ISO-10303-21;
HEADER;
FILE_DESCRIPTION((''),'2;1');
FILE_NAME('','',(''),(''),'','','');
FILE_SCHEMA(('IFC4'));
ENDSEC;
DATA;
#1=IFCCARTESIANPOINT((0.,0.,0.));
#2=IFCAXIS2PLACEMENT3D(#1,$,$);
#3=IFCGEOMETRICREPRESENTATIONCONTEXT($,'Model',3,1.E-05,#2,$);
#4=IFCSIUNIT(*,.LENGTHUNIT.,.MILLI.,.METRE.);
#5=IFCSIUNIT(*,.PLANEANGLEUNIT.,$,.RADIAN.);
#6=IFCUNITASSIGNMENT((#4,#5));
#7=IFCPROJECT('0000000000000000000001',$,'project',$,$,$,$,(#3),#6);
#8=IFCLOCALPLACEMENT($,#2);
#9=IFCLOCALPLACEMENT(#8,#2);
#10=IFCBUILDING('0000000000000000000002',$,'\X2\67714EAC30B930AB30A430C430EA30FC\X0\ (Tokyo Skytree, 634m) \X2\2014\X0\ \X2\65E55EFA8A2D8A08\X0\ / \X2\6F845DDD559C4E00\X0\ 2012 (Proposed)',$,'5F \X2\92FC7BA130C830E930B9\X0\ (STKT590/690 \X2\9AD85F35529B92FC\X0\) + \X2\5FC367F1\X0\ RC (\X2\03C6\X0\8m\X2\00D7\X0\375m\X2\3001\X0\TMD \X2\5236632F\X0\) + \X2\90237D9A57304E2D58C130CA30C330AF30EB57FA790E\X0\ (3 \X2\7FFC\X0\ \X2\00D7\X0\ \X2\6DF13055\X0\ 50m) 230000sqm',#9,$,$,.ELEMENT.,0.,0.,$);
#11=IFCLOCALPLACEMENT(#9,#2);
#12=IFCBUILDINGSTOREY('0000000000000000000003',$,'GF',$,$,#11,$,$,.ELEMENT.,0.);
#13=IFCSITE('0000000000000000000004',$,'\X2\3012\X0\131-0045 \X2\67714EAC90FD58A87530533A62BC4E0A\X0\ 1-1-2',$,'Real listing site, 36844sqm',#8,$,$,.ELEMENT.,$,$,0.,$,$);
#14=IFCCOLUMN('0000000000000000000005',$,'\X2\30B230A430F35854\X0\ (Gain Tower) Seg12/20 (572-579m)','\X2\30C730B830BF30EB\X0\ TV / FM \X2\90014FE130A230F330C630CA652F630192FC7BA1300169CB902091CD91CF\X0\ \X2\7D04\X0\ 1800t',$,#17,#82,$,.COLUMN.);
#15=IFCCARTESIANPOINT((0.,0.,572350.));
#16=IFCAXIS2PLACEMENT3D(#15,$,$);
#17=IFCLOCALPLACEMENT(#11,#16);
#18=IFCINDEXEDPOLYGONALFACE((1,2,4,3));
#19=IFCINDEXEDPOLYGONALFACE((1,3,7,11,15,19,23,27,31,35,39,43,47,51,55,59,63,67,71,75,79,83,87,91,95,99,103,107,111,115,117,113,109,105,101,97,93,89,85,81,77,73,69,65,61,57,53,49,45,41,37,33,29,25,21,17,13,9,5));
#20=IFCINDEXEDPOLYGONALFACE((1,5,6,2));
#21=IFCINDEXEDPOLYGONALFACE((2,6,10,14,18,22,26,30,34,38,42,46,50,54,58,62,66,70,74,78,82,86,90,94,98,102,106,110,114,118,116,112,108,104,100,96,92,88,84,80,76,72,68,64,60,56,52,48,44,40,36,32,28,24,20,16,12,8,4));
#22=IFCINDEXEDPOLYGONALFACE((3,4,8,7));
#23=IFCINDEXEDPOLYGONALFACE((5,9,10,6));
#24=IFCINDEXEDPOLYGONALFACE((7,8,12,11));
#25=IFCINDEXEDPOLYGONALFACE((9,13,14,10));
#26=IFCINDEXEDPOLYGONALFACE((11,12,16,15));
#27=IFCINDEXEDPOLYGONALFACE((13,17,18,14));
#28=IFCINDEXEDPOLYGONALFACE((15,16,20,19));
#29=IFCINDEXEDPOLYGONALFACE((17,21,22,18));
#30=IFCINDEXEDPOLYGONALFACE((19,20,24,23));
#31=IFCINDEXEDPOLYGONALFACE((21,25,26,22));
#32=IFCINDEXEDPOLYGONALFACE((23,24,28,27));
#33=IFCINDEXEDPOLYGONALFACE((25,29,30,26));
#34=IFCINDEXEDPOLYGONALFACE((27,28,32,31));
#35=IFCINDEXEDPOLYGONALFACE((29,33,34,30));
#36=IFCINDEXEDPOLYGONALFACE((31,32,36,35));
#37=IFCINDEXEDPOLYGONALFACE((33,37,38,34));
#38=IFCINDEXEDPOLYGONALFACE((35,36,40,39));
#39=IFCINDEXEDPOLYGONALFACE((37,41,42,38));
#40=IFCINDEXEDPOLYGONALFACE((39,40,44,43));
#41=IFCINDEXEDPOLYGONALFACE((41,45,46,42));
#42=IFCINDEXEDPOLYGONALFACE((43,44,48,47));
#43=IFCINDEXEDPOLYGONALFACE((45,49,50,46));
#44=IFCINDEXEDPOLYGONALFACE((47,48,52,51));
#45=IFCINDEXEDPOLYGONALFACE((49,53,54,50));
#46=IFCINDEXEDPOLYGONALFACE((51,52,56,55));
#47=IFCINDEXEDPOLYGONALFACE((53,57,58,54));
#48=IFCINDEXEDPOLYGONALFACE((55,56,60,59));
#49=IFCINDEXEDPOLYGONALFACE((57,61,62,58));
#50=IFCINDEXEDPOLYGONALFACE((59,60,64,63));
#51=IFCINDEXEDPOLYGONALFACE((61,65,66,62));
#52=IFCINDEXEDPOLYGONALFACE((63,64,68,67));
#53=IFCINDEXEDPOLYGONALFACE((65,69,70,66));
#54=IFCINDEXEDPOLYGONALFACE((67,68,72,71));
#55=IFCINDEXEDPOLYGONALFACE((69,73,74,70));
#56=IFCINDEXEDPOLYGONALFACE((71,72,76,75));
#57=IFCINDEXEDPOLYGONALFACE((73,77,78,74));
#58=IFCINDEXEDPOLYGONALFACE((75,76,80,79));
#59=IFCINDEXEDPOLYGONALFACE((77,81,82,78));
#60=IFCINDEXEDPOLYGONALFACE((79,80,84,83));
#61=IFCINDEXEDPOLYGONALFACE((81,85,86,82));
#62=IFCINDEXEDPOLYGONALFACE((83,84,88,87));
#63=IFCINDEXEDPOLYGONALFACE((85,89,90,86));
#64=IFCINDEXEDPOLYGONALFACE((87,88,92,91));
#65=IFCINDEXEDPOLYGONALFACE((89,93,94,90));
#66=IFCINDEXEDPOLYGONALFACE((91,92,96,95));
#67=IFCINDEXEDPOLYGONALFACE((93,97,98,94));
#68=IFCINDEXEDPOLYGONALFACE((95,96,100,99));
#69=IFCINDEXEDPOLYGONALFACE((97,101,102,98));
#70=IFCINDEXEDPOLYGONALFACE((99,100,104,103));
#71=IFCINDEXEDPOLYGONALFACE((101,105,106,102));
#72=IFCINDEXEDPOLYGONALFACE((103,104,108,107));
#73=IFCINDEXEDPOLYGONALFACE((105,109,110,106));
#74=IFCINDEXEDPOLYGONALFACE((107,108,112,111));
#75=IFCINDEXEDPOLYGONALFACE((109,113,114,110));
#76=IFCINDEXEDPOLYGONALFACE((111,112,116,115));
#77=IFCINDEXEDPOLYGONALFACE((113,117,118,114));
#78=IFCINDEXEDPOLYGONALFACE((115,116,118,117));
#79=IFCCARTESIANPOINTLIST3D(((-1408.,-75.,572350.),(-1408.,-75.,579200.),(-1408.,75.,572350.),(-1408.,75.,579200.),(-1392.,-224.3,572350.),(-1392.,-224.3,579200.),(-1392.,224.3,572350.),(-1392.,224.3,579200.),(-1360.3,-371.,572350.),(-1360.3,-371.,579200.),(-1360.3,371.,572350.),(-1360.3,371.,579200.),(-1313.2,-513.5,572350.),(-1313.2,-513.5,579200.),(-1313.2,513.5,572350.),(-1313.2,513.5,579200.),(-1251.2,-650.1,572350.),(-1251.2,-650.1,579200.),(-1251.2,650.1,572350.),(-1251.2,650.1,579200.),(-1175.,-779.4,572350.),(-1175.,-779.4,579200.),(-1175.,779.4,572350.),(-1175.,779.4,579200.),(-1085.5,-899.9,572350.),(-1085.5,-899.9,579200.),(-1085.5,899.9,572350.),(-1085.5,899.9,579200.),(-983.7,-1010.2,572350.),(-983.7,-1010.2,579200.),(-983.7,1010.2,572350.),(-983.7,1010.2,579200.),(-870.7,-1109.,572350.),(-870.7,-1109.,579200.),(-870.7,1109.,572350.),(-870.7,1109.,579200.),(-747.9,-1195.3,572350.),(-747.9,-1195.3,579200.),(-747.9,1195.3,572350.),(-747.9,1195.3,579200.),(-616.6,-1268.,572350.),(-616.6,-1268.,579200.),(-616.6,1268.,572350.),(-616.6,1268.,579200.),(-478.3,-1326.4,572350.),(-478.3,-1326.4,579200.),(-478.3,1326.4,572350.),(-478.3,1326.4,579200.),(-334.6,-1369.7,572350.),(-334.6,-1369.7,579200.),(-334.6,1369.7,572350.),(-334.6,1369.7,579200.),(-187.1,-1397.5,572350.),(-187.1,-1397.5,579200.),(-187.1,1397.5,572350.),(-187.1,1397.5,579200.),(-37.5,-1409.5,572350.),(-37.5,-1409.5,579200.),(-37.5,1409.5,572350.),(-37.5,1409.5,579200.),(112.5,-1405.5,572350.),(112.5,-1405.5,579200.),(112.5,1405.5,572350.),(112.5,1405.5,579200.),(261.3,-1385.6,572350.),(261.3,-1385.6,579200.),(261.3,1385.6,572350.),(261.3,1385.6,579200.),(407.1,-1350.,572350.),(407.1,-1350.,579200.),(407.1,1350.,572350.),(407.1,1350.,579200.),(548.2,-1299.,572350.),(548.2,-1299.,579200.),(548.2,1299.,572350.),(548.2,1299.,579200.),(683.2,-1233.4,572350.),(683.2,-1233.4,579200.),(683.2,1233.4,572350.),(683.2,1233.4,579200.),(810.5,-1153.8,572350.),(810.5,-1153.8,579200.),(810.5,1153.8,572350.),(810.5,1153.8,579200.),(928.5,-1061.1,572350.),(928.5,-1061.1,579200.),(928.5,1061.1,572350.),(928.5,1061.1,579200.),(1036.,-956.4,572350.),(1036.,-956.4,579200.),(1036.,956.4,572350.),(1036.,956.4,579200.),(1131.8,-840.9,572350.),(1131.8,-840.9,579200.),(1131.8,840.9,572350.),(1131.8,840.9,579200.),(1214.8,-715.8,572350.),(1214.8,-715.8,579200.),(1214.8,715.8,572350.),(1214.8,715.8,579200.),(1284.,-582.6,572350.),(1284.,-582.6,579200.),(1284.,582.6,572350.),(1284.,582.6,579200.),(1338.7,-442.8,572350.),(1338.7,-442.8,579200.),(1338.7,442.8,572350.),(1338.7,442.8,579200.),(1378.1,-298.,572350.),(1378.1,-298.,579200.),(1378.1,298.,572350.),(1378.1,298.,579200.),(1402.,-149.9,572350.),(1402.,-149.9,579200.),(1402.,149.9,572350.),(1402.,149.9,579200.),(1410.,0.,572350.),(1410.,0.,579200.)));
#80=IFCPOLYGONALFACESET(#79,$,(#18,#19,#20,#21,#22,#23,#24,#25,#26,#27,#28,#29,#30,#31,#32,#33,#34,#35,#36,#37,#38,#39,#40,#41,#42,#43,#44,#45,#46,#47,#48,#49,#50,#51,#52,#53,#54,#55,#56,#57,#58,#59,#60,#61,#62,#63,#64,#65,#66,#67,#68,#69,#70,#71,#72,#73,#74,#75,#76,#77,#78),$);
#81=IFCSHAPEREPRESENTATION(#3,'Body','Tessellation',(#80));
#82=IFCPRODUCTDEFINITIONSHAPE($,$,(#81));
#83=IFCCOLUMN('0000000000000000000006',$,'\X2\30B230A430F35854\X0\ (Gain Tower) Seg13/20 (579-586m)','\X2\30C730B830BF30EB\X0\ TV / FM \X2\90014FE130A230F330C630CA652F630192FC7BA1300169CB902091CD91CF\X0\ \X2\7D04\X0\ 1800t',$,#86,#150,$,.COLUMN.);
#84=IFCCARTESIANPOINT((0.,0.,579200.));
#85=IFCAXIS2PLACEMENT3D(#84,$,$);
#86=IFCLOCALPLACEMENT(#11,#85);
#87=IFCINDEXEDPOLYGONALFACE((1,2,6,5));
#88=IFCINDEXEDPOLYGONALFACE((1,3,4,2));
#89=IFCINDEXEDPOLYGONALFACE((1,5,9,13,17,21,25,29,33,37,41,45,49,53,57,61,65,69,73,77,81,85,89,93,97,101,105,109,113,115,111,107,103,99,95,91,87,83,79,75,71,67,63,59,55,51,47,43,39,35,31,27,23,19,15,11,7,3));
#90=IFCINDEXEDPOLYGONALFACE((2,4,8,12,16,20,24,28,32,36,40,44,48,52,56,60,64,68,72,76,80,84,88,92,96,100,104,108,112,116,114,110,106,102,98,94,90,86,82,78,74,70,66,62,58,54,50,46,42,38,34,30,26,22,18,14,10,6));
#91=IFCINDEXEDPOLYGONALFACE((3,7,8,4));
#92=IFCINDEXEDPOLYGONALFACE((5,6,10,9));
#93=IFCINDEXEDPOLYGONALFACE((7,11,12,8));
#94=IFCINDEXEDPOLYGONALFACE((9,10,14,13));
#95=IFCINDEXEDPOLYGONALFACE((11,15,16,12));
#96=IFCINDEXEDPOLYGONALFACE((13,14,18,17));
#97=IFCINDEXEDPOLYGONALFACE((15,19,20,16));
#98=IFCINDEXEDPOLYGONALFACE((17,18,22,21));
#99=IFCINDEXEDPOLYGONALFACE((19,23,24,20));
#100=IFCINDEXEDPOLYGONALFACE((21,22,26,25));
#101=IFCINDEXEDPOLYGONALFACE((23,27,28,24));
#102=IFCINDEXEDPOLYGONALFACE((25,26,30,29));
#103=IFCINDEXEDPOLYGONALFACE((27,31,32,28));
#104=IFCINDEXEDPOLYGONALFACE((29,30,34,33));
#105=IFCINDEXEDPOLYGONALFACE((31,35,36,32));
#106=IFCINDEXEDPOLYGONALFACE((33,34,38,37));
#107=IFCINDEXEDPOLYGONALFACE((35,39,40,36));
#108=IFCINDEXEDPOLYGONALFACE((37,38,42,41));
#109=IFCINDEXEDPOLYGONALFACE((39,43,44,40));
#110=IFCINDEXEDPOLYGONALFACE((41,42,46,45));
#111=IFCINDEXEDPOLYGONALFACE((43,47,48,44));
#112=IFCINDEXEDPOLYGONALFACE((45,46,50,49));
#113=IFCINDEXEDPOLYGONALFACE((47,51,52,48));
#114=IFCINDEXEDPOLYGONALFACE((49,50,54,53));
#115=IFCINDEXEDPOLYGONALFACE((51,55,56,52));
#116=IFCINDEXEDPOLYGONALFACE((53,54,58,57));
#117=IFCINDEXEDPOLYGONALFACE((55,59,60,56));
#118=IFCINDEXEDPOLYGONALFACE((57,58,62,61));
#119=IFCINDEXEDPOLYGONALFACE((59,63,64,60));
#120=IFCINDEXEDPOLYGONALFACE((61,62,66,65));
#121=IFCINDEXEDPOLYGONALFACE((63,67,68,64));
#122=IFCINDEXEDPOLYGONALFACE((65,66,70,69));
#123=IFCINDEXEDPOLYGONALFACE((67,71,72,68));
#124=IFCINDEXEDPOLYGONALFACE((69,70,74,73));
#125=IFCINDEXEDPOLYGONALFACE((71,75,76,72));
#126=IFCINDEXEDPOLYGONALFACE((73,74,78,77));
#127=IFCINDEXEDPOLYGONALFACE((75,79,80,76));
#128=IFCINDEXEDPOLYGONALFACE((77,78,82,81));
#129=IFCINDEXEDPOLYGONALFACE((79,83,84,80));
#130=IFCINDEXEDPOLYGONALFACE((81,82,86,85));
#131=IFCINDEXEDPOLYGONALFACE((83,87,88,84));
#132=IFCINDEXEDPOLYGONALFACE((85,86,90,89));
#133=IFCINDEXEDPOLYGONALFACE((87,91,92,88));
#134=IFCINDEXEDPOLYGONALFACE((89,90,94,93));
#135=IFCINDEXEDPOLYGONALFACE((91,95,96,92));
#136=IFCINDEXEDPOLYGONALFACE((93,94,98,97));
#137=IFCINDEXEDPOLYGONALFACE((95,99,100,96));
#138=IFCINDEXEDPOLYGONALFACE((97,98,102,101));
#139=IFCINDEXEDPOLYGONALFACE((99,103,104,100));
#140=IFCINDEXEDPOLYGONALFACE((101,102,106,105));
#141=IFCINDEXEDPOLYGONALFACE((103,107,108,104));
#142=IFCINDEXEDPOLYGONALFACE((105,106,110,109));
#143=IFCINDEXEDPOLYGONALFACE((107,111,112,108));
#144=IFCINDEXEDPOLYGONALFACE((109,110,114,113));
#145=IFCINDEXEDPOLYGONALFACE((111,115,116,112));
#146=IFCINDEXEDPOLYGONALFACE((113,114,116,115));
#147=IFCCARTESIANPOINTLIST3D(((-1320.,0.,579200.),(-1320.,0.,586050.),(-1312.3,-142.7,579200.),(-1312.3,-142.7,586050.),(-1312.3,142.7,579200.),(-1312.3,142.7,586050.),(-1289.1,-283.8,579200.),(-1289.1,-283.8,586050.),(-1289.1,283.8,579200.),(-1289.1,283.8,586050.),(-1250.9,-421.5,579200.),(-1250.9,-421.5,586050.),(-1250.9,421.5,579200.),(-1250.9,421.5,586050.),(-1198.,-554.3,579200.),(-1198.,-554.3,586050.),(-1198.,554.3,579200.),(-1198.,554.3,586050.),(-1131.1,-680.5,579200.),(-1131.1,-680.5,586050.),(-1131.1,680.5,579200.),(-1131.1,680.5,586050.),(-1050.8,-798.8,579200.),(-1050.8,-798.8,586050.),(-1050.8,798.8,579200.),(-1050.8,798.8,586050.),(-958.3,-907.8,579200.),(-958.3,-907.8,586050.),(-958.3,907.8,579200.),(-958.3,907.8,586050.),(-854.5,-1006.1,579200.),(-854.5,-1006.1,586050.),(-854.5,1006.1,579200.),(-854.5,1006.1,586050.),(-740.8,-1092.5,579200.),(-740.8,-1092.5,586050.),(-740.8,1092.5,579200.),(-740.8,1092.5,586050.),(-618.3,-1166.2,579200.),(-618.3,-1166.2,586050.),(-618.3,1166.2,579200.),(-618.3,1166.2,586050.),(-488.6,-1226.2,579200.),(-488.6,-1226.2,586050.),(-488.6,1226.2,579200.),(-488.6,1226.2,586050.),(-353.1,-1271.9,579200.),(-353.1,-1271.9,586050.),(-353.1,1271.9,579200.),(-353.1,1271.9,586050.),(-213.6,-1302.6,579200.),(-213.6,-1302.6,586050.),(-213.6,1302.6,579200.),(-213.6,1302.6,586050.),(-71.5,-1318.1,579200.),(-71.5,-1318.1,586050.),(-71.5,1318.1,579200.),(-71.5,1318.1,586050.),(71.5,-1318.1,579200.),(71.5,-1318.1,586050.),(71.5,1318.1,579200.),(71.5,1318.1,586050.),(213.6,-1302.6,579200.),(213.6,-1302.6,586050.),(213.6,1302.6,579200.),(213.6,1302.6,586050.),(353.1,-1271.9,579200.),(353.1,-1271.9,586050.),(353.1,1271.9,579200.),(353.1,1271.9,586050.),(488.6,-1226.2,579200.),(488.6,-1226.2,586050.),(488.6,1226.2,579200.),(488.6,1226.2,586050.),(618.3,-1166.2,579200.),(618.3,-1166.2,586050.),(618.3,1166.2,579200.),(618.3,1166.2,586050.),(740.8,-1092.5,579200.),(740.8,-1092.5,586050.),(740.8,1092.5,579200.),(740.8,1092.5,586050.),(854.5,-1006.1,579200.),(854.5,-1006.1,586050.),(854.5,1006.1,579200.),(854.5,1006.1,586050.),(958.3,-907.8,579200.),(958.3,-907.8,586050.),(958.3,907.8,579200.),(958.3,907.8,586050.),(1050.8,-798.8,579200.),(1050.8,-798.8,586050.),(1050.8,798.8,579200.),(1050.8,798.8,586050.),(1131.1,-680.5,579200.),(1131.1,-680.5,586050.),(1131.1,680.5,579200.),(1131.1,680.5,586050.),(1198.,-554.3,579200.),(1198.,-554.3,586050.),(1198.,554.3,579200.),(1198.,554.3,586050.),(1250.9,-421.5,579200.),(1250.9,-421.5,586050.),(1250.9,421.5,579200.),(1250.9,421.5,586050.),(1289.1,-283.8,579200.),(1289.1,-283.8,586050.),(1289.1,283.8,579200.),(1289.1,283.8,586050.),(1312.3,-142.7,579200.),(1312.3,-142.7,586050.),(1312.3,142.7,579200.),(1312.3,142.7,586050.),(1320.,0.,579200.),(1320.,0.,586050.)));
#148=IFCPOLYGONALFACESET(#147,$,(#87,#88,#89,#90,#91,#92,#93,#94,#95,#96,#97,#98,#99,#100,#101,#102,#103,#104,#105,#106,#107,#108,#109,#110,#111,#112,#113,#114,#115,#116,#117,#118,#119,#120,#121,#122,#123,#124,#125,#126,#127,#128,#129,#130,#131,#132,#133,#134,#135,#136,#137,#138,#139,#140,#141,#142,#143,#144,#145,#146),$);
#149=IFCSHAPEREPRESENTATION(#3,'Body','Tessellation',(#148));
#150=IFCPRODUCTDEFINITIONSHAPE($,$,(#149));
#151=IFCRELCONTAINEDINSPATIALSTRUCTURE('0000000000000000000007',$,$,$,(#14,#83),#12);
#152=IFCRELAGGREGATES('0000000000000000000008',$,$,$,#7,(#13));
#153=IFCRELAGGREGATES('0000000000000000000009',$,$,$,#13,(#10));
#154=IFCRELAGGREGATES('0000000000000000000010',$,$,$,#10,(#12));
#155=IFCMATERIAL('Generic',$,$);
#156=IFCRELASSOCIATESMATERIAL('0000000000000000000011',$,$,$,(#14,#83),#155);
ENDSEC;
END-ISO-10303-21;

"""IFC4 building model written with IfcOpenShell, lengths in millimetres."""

from ifc_helpers import new_model, si_unit, frame, origin, origin_2d, place, context, project, spatial, circle, extrude, material, element, save


model = new_model("IFC4")

# Units and contexts
model_context = context("Model", 3, precision=1e-05, world=origin())
ifc_project = project(units=[si_unit("LENGTHUNIT", "METRE", prefix="MILLI"), si_unit("PLANEANGLEUNIT", "RADIAN")], contexts=[model_context])

# Site, building, storey
site_placement = place(None, origin())
site = spatial("IfcSite", under=ifc_project, at=site_placement, Name="〒131-0045 東京都墨田区押上 1-1-2", ObjectType="Real listing site, 36844sqm", CompositionType="ELEMENT", RefElevation=0.0)
building_placement = place(site_placement, origin())
building = spatial("IfcBuilding", under=site, at=building_placement, Name="東京スカイツリー (Tokyo Skytree, 634m) — 日建設計 / 澄川喜一 2012 (Proposed)", ObjectType="5F 鋼管トラス (STKT590/690 高張力鋼) + 心柱 RC (φ8m×375m、TMD 制振) + 連続地中壁ナックル基礎 (3 翼 × 深さ 50m) 230000sqm", CompositionType="ELEMENT", ElevationOfRefHeight=0.0, ElevationOfTerrain=0.0)
storey_placement = place(building_placement, origin())
storey = spatial("IfcBuildingStorey", under=building, at=storey_placement, Name="GF", CompositionType="ELEMENT", Elevation=0.0)

# Columns
ifc_material = material(Name="Generic")
column_1_placement = place(storey_placement, frame((0.0, 0.0, 572350.0)))
element("IfcColumn", 1, at=column_1_placement, inside=storey, material=ifc_material, Name="ゲイン塔 (Gain Tower) Seg12/20 (572-579m)", Description="デジタル TV / FM 送信アンテナ支持鋼管、構造重量 約 1800t", PredefinedType="COLUMN", context=model_context, shape_type="SweptSolid", body=[
    extrude(circle(Radius=1410.0, at=origin_2d()), frame((0.0, 0.0, 572350.0)), (0.0, 0.0, 1.0), 6850.0),
])
column_2_placement = place(storey_placement, frame((0.0, 0.0, 579200.0)))
element("IfcColumn", 2, at=column_2_placement, inside=storey, material=ifc_material, Name="ゲイン塔 (Gain Tower) Seg13/20 (579-586m)", Description="デジタル TV / FM 送信アンテナ支持鋼管、構造重量 約 1800t", PredefinedType="COLUMN", context=model_context, shape_type="SweptSolid", body=[
    extrude(circle(Radius=1320.0, at=origin_2d()), frame((0.0, 0.0, 579200.0)), (0.0, 0.0, 1.0), 6850.0),
])

save(model, "model.ifc")
